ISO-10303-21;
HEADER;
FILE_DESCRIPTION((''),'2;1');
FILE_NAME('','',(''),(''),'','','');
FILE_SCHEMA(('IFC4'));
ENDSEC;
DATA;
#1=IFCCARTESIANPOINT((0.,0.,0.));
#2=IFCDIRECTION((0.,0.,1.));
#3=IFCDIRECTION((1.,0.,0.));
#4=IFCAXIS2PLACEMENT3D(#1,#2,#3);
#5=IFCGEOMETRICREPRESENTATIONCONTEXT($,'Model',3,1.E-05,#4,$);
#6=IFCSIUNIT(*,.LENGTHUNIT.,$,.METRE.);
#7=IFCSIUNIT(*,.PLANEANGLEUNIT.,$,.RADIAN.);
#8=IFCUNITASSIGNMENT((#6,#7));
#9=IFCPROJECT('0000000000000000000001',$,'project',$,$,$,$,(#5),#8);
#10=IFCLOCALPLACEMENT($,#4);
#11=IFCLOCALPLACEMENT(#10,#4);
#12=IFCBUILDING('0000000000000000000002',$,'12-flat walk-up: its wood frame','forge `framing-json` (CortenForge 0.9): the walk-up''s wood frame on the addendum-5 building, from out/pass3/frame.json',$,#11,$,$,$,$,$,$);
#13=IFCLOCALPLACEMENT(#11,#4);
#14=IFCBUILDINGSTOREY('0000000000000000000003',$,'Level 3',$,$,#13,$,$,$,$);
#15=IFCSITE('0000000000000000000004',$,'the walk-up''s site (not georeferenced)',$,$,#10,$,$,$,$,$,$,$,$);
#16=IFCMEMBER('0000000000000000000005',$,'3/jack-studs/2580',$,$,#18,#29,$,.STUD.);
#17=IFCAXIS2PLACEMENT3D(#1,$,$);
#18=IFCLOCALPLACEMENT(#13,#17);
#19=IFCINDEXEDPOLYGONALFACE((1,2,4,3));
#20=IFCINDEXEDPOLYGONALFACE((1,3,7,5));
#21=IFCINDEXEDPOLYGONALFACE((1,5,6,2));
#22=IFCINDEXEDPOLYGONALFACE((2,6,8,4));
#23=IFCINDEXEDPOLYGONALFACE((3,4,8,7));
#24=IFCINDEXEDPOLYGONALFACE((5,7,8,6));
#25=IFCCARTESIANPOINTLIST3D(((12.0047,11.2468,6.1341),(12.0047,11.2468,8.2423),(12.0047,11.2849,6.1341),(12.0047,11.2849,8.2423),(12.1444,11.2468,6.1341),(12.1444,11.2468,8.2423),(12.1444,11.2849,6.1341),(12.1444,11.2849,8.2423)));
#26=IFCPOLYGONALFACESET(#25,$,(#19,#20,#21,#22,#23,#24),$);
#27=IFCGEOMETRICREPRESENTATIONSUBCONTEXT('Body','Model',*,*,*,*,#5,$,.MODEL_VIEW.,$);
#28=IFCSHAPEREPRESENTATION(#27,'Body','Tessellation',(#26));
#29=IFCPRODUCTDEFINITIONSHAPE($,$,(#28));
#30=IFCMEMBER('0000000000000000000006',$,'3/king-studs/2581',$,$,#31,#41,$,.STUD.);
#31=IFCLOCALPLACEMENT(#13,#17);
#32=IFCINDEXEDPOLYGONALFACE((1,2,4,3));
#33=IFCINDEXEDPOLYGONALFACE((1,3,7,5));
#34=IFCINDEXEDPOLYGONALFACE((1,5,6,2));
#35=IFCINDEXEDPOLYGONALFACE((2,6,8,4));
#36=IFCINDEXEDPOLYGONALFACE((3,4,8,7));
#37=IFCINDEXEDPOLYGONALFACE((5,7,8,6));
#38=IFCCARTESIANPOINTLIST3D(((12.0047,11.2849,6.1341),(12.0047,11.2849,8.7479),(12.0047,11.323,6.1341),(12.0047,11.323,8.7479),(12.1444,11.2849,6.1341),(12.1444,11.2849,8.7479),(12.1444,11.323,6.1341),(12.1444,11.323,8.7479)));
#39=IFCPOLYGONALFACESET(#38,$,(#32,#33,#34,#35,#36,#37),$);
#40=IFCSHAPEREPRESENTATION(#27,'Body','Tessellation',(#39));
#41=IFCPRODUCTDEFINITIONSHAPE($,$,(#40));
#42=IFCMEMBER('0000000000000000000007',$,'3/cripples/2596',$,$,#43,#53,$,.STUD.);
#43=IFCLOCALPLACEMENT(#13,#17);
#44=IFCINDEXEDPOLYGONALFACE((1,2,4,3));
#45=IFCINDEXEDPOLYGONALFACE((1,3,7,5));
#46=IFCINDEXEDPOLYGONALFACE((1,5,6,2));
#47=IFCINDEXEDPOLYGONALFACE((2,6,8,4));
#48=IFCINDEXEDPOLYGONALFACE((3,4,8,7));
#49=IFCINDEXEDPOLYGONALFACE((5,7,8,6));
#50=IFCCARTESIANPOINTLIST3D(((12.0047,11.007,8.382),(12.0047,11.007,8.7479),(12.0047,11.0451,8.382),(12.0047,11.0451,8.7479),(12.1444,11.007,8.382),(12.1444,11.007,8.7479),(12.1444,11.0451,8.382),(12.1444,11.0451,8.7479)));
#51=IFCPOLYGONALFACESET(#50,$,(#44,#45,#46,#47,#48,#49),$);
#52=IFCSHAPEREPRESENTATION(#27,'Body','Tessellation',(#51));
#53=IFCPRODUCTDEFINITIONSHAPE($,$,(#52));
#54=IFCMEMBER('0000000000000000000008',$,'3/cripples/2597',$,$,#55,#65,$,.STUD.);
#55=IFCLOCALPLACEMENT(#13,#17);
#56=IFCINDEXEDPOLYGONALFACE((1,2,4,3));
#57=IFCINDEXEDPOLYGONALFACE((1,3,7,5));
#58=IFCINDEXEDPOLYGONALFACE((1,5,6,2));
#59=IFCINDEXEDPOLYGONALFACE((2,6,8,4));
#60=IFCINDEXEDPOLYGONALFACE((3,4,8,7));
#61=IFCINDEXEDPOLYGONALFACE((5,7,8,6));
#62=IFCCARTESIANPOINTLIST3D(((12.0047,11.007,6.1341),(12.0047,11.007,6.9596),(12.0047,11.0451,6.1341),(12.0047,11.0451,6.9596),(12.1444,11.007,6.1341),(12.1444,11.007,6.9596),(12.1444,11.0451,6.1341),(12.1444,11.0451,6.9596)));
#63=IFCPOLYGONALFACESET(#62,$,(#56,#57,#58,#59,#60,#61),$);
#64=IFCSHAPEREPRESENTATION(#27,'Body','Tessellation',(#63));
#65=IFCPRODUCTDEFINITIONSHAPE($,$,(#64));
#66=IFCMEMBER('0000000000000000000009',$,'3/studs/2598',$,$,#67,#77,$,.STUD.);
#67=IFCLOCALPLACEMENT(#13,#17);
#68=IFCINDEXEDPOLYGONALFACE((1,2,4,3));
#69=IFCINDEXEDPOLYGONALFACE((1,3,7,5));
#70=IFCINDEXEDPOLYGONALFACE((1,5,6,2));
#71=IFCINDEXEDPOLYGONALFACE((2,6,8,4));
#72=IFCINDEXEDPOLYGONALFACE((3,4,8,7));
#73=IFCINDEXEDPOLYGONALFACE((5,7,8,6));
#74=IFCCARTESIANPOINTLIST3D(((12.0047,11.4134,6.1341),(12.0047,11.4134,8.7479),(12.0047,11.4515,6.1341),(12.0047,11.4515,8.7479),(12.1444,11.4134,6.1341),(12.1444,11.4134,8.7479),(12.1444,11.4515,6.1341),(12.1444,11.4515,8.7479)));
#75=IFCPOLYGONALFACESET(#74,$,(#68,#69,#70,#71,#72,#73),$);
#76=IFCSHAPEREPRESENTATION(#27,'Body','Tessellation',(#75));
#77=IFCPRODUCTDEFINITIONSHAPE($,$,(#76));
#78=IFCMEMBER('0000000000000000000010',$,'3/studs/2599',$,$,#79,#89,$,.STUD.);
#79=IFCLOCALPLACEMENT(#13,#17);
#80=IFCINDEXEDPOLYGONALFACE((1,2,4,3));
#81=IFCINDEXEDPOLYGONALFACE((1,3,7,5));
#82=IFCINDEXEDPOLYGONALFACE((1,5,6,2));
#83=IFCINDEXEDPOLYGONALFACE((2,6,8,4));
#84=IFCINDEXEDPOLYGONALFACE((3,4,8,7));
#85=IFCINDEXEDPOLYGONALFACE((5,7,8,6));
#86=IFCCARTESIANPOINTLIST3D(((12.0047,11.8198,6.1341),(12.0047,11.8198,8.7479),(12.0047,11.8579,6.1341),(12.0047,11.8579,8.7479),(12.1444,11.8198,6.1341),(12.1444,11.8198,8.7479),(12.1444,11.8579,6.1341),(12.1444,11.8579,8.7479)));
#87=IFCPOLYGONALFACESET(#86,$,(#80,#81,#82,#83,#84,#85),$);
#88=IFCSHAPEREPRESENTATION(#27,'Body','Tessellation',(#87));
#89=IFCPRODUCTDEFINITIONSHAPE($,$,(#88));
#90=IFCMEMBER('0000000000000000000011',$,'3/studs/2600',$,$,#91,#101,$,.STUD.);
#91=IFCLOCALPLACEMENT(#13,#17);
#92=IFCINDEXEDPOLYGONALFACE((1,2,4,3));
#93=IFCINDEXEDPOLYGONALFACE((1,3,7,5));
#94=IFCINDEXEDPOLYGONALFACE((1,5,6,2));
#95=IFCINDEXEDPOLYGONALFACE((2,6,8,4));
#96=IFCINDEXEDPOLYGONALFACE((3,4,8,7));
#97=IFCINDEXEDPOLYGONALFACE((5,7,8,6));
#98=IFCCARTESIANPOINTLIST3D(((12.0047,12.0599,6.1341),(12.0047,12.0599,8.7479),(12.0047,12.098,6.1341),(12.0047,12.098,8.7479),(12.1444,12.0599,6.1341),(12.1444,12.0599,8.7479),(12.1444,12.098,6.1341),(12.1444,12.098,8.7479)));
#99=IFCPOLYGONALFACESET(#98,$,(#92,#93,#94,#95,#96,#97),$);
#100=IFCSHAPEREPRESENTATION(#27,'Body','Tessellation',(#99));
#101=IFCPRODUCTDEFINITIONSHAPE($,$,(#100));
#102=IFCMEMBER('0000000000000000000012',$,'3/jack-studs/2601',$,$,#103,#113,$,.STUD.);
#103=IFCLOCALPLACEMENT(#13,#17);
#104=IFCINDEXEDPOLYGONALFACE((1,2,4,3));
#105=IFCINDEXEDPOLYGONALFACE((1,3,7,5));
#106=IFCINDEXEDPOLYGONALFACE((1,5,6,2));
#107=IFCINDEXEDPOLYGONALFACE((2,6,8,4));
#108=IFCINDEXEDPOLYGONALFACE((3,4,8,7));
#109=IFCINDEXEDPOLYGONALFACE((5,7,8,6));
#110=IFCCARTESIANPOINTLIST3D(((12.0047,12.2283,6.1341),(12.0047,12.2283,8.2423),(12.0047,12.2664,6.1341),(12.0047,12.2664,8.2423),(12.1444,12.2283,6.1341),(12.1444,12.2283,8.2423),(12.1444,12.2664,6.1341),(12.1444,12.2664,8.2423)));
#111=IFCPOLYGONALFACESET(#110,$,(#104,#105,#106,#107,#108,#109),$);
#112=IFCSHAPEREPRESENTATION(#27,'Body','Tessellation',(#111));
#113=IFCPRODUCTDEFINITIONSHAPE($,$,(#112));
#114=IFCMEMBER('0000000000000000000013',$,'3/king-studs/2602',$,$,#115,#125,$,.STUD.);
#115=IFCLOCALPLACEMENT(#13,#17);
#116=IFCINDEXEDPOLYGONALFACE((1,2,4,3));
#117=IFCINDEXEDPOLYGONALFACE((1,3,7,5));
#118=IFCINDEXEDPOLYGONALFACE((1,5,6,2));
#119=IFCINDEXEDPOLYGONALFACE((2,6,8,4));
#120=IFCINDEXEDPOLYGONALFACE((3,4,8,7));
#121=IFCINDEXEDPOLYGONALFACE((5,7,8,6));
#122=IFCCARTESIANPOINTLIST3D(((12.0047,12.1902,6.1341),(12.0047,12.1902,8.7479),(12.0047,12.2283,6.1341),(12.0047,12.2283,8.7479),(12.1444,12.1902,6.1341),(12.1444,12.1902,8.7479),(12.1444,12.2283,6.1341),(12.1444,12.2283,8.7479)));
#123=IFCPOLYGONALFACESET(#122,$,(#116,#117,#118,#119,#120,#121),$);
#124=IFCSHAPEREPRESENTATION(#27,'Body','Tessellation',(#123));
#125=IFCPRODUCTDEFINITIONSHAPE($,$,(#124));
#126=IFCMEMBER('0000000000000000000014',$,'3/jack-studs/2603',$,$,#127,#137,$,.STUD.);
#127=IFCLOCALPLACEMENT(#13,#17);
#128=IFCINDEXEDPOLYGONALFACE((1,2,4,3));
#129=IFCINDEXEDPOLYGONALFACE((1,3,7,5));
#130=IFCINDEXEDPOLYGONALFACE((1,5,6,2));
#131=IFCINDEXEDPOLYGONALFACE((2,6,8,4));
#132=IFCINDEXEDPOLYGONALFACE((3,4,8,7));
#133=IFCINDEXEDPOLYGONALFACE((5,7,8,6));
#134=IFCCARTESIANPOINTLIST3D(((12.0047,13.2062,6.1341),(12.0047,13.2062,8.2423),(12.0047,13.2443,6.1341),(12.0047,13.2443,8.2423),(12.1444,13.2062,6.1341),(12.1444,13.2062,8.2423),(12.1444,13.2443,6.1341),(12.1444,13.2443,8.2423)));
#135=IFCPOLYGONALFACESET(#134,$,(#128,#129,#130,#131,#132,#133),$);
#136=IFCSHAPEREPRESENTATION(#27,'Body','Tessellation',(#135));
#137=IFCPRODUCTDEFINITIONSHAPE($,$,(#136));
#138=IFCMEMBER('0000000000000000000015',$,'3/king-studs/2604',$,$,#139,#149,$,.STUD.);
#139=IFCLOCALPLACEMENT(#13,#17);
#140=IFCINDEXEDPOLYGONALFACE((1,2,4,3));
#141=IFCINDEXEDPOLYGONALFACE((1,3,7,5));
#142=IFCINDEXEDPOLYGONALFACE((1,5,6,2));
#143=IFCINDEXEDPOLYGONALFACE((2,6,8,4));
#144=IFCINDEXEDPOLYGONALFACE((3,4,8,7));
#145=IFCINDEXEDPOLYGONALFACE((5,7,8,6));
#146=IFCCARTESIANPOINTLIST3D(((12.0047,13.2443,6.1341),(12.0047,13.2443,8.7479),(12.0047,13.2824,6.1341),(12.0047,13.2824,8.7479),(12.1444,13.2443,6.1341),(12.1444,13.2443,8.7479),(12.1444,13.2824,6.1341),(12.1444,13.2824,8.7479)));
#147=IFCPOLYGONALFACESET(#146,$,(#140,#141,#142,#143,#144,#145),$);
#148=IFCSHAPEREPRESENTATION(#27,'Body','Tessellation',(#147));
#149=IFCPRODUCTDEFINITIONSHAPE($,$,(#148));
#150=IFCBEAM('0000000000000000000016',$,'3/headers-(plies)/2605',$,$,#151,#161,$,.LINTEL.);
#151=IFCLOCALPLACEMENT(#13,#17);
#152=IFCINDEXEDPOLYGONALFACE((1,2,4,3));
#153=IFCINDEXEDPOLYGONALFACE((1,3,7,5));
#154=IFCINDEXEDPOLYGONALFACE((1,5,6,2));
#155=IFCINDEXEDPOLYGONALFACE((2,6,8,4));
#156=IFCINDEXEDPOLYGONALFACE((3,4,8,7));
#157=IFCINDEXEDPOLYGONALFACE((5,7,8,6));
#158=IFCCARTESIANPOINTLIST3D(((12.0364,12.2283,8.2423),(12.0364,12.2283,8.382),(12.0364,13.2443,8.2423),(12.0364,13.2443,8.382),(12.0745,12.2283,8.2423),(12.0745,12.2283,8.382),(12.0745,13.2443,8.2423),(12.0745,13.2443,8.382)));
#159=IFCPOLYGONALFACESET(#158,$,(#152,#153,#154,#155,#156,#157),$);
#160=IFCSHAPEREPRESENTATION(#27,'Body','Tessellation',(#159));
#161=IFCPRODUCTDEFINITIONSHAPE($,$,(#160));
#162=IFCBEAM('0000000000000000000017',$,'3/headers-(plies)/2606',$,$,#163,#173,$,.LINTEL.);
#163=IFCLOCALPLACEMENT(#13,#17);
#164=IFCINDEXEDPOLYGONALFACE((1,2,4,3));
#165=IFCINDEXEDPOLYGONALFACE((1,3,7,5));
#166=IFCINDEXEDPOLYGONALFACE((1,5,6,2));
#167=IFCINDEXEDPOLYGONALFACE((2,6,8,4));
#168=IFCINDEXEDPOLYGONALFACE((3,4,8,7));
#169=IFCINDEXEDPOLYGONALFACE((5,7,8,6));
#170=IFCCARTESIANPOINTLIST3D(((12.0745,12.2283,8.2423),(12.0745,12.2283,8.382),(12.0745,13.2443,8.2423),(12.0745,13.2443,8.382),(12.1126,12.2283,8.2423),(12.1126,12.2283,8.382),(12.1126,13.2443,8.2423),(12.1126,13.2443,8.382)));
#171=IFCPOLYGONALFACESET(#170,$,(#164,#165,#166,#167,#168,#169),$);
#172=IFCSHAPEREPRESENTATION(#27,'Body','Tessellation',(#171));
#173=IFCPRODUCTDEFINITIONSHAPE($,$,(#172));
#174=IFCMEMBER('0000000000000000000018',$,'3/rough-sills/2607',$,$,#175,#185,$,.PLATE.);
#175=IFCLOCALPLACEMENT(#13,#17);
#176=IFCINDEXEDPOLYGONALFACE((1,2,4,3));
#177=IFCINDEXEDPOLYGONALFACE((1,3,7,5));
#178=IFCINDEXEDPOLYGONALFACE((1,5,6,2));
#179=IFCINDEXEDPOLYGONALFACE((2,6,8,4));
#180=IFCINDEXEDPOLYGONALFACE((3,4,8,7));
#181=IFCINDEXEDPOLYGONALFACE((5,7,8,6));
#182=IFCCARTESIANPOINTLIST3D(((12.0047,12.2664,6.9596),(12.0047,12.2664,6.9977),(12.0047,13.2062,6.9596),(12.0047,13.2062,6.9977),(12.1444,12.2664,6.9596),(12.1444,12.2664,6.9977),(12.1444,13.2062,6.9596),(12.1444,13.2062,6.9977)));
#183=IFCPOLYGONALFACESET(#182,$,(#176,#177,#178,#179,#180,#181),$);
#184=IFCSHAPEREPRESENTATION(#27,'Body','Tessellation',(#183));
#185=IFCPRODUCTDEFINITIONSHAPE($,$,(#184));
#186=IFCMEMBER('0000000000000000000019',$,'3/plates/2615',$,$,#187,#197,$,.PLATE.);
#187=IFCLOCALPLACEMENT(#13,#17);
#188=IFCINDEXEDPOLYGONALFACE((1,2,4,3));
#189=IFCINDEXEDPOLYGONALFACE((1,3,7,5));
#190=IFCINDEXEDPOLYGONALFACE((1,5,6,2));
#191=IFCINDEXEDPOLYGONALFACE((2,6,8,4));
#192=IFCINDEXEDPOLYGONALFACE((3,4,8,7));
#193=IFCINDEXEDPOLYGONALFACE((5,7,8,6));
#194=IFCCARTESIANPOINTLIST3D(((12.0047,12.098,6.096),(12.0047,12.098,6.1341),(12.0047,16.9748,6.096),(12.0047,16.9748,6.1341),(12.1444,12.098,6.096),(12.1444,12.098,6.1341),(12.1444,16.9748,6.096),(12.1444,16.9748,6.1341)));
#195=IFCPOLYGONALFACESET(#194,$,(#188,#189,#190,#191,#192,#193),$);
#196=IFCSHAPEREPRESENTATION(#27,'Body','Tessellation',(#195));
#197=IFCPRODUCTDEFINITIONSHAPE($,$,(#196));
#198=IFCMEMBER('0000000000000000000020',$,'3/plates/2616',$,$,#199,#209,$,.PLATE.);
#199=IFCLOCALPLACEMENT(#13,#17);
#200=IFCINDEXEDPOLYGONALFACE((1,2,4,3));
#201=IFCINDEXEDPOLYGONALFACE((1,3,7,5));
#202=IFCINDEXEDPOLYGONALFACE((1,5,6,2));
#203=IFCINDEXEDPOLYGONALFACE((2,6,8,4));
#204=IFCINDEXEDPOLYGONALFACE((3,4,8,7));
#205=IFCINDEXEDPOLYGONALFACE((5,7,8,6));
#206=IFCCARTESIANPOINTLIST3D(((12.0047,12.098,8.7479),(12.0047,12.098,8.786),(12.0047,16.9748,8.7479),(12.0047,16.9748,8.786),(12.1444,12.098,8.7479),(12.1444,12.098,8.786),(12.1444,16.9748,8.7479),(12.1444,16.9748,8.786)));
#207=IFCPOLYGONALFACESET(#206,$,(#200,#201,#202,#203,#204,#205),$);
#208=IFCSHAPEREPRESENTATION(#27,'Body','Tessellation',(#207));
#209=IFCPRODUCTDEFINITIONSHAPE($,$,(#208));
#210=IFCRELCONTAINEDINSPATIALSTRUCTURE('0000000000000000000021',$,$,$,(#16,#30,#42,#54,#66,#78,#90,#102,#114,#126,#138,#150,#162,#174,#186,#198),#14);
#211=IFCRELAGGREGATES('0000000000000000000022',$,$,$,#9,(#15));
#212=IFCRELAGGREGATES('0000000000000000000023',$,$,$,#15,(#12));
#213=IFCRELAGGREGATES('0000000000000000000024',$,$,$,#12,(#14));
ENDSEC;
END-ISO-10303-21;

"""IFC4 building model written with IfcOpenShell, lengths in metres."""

from ifc_helpers import new_model, si_unit, frame, frame_2d, origin, origin_with_axes, place, context, subcontext, project, spatial, rectangle, extrude, element, save


model = new_model("IFC4")

# Units and contexts
model_context = context("Model", 3, precision=1e-05, world=origin_with_axes())
body_context = subcontext(model_context, "Body", "Model", "MODEL_VIEW")
ifc_project = project(units=[si_unit("LENGTHUNIT", "METRE"), si_unit("PLANEANGLEUNIT", "RADIAN")], contexts=[model_context])

# Site, building, storey
site_placement = place(None, origin_with_axes())
site = spatial("IfcSite", under=ifc_project, at=site_placement, Name="the walk-up's site (not georeferenced)")
building_placement = place(site_placement, origin_with_axes())
building = spatial("IfcBuilding", under=site, at=building_placement, Name="12-flat walk-up: its wood frame", Description="forge `framing-json` (CortenForge 0.9): the walk-up's wood frame on the addendum-5 building, from out/pass3/frame.json")
storey_placement = place(building_placement, origin_with_axes())
storey = spatial("IfcBuildingStorey", under=building, at=storey_placement, Name="Level 3")

# Members
member_1_placement = place(storey_placement, frame((12.0047, 11.2468, 6.1341), z_axis=(0.0, 0.0, 1.0), x_axis=(1.0, 0.0, 0.0)))
element("IfcMember", 1, at=member_1_placement, inside=storey, Name="3/jack-studs/2580", PredefinedType="STUD", context=body_context, shape_type="SweptSolid", body=[
    extrude(rectangle(XDim=0.1397, YDim=0.0381, at=frame_2d((0.0698, 0.0191))), origin(), (0.0, 0.0, 1.0), 2.1082),
])
member_2_placement = place(storey_placement, frame((12.0047, 11.2849, 6.1341), z_axis=(0.0, 0.0, 1.0), x_axis=(1.0, 0.0, 0.0)))
element("IfcMember", 2, at=member_2_placement, inside=storey, Name="3/king-studs/2581", PredefinedType="STUD", context=body_context, shape_type="SweptSolid", body=[
    extrude(rectangle(XDim=0.1397, YDim=0.0381, at=frame_2d((0.0698, 0.0191))), origin(), (0.0, 0.0, 1.0), 2.6138),
])
member_3_placement = place(storey_placement, frame((12.0047, 11.007, 8.382), z_axis=(0.0, 0.0, 1.0), x_axis=(1.0, 0.0, 0.0)))
element("IfcMember", 3, at=member_3_placement, inside=storey, Name="3/cripples/2596", PredefinedType="STUD", context=body_context, shape_type="SweptSolid", body=[
    extrude(rectangle(XDim=0.1397, YDim=0.0381, at=frame_2d((0.0698, 0.0191))), origin(), (0.0, 0.0, 1.0), 0.3659),
])
member_4_placement = place(storey_placement, frame((12.0047, 11.007, 6.1341), z_axis=(0.0, 0.0, 1.0), x_axis=(1.0, 0.0, 0.0)))
element("IfcMember", 4, at=member_4_placement, inside=storey, Name="3/cripples/2597", PredefinedType="STUD", context=body_context, shape_type="SweptSolid", body=[
    extrude(rectangle(XDim=0.1397, YDim=0.0381, at=frame_2d((0.0698, 0.0191))), origin(), (0.0, 0.0, 1.0), 0.8255),
])
for number, where, z_axis, x_axis, name in (
    (5, (12.0047, 11.4134, 6.1341), (0.0, 0.0, 1.0), (1.0, 0.0, 0.0), "3/studs/2598"),
    (6, (12.0047, 11.8198, 6.1341), (0.0, 0.0, 1.0), (1.0, 0.0, 0.0), "3/studs/2599"),
    (7, (12.0047, 12.0599, 6.1341), (0.0, 0.0, 1.0), (1.0, 0.0, 0.0), "3/studs/2600"),
):
    element("IfcMember", number, at=place(storey_placement, frame(where, z_axis=z_axis, x_axis=x_axis)), inside=storey, Name=name, PredefinedType="STUD", context=body_context, shape_type="SweptSolid", body=[
        extrude(rectangle(XDim=0.1397, YDim=0.0381, at=frame_2d((0.0698, 0.0191))), origin(), (0.0, 0.0, 1.0), 2.6138),
    ])
member_5_placement = place(storey_placement, frame((12.0047, 12.2283, 6.1341), z_axis=(0.0, 0.0, 1.0), x_axis=(1.0, 0.0, 0.0)))
element("IfcMember", 8, at=member_5_placement, inside=storey, Name="3/jack-studs/2601", PredefinedType="STUD", context=body_context, shape_type="SweptSolid", body=[
    extrude(rectangle(XDim=0.1397, YDim=0.0381, at=frame_2d((0.0698, 0.0191))), origin(), (0.0, 0.0, 1.0), 2.1082),
])
member_6_placement = place(storey_placement, frame((12.0047, 12.1902, 6.1341), z_axis=(0.0, 0.0, 1.0), x_axis=(1.0, 0.0, 0.0)))
element("IfcMember", 9, at=member_6_placement, inside=storey, Name="3/king-studs/2602", PredefinedType="STUD", context=body_context, shape_type="SweptSolid", body=[
    extrude(rectangle(XDim=0.1397, YDim=0.0381, at=frame_2d((0.0698, 0.0191))), origin(), (0.0, 0.0, 1.0), 2.6138),
])
member_7_placement = place(storey_placement, frame((12.0047, 13.2062, 6.1341), z_axis=(0.0, 0.0, 1.0), x_axis=(1.0, 0.0, 0.0)))
element("IfcMember", 10, at=member_7_placement, inside=storey, Name="3/jack-studs/2603", PredefinedType="STUD", context=body_context, shape_type="SweptSolid", body=[
    extrude(rectangle(XDim=0.1397, YDim=0.0381, at=frame_2d((0.0698, 0.0191))), origin(), (0.0, 0.0, 1.0), 2.1082),
])
member_8_placement = place(storey_placement, frame((12.0047, 13.2443, 6.1341), z_axis=(0.0, 0.0, 1.0), x_axis=(1.0, 0.0, 0.0)))
element("IfcMember", 11, at=member_8_placement, inside=storey, Name="3/king-studs/2604", PredefinedType="STUD", context=body_context, shape_type="SweptSolid", body=[
    extrude(rectangle(XDim=0.1397, YDim=0.0381, at=frame_2d((0.0698, 0.0191))), origin(), (0.0, 0.0, 1.0), 2.6138),
])

# Beams
for number, where, z_axis, x_axis, name in (
    (12, (12.0364, 12.2283, 8.2423), (0.0, 0.0, 1.0), (1.0, 0.0, 0.0), "3/headers-(plies)/2605"),
    (13, (12.0745, 12.2283, 8.2423), (0.0, 0.0, 1.0), (1.0, 0.0, 0.0), "3/headers-(plies)/2606"),
):
    element("IfcBeam", number, at=place(storey_placement, frame(where, z_axis=z_axis, x_axis=x_axis)), inside=storey, Name=name, PredefinedType="LINTEL", context=body_context, shape_type="SweptSolid", body=[
        extrude(rectangle(XDim=0.0381, YDim=1.016, at=frame_2d((0.0191, 0.508))), origin(), (0.0, 0.0, 1.0), 0.1397),
    ])

# Members
member_9_placement = place(storey_placement, frame((12.0047, 12.2664, 6.9596), z_axis=(0.0, 0.0, 1.0), x_axis=(1.0, 0.0, 0.0)))
element("IfcMember", 14, at=member_9_placement, inside=storey, Name="3/rough-sills/2607", PredefinedType="PLATE", context=body_context, shape_type="SweptSolid", body=[
    extrude(rectangle(XDim=0.1397, YDim=0.9398, at=frame_2d((0.0698, 0.4699))), origin(), (0.0, 0.0, 1.0), 0.0381),
])
for number, where, z_axis, x_axis, name in (
    (15, (12.0047, 12.098, 6.096), (0.0, 0.0, 1.0), (1.0, 0.0, 0.0), "3/plates/2615"),
    (16, (12.0047, 12.098, 8.7479), (0.0, 0.0, 1.0), (1.0, 0.0, 0.0), "3/plates/2616"),
):
    element("IfcMember", number, at=place(storey_placement, frame(where, z_axis=z_axis, x_axis=x_axis)), inside=storey, Name=name, PredefinedType="PLATE", context=body_context, shape_type="SweptSolid", body=[
        extrude(rectangle(XDim=0.1397, YDim=4.8768, at=frame_2d((0.0698, 2.4384))), origin(), (0.0, 0.0, 1.0), 0.0381),
    ])

save(model, "model.ifc")
